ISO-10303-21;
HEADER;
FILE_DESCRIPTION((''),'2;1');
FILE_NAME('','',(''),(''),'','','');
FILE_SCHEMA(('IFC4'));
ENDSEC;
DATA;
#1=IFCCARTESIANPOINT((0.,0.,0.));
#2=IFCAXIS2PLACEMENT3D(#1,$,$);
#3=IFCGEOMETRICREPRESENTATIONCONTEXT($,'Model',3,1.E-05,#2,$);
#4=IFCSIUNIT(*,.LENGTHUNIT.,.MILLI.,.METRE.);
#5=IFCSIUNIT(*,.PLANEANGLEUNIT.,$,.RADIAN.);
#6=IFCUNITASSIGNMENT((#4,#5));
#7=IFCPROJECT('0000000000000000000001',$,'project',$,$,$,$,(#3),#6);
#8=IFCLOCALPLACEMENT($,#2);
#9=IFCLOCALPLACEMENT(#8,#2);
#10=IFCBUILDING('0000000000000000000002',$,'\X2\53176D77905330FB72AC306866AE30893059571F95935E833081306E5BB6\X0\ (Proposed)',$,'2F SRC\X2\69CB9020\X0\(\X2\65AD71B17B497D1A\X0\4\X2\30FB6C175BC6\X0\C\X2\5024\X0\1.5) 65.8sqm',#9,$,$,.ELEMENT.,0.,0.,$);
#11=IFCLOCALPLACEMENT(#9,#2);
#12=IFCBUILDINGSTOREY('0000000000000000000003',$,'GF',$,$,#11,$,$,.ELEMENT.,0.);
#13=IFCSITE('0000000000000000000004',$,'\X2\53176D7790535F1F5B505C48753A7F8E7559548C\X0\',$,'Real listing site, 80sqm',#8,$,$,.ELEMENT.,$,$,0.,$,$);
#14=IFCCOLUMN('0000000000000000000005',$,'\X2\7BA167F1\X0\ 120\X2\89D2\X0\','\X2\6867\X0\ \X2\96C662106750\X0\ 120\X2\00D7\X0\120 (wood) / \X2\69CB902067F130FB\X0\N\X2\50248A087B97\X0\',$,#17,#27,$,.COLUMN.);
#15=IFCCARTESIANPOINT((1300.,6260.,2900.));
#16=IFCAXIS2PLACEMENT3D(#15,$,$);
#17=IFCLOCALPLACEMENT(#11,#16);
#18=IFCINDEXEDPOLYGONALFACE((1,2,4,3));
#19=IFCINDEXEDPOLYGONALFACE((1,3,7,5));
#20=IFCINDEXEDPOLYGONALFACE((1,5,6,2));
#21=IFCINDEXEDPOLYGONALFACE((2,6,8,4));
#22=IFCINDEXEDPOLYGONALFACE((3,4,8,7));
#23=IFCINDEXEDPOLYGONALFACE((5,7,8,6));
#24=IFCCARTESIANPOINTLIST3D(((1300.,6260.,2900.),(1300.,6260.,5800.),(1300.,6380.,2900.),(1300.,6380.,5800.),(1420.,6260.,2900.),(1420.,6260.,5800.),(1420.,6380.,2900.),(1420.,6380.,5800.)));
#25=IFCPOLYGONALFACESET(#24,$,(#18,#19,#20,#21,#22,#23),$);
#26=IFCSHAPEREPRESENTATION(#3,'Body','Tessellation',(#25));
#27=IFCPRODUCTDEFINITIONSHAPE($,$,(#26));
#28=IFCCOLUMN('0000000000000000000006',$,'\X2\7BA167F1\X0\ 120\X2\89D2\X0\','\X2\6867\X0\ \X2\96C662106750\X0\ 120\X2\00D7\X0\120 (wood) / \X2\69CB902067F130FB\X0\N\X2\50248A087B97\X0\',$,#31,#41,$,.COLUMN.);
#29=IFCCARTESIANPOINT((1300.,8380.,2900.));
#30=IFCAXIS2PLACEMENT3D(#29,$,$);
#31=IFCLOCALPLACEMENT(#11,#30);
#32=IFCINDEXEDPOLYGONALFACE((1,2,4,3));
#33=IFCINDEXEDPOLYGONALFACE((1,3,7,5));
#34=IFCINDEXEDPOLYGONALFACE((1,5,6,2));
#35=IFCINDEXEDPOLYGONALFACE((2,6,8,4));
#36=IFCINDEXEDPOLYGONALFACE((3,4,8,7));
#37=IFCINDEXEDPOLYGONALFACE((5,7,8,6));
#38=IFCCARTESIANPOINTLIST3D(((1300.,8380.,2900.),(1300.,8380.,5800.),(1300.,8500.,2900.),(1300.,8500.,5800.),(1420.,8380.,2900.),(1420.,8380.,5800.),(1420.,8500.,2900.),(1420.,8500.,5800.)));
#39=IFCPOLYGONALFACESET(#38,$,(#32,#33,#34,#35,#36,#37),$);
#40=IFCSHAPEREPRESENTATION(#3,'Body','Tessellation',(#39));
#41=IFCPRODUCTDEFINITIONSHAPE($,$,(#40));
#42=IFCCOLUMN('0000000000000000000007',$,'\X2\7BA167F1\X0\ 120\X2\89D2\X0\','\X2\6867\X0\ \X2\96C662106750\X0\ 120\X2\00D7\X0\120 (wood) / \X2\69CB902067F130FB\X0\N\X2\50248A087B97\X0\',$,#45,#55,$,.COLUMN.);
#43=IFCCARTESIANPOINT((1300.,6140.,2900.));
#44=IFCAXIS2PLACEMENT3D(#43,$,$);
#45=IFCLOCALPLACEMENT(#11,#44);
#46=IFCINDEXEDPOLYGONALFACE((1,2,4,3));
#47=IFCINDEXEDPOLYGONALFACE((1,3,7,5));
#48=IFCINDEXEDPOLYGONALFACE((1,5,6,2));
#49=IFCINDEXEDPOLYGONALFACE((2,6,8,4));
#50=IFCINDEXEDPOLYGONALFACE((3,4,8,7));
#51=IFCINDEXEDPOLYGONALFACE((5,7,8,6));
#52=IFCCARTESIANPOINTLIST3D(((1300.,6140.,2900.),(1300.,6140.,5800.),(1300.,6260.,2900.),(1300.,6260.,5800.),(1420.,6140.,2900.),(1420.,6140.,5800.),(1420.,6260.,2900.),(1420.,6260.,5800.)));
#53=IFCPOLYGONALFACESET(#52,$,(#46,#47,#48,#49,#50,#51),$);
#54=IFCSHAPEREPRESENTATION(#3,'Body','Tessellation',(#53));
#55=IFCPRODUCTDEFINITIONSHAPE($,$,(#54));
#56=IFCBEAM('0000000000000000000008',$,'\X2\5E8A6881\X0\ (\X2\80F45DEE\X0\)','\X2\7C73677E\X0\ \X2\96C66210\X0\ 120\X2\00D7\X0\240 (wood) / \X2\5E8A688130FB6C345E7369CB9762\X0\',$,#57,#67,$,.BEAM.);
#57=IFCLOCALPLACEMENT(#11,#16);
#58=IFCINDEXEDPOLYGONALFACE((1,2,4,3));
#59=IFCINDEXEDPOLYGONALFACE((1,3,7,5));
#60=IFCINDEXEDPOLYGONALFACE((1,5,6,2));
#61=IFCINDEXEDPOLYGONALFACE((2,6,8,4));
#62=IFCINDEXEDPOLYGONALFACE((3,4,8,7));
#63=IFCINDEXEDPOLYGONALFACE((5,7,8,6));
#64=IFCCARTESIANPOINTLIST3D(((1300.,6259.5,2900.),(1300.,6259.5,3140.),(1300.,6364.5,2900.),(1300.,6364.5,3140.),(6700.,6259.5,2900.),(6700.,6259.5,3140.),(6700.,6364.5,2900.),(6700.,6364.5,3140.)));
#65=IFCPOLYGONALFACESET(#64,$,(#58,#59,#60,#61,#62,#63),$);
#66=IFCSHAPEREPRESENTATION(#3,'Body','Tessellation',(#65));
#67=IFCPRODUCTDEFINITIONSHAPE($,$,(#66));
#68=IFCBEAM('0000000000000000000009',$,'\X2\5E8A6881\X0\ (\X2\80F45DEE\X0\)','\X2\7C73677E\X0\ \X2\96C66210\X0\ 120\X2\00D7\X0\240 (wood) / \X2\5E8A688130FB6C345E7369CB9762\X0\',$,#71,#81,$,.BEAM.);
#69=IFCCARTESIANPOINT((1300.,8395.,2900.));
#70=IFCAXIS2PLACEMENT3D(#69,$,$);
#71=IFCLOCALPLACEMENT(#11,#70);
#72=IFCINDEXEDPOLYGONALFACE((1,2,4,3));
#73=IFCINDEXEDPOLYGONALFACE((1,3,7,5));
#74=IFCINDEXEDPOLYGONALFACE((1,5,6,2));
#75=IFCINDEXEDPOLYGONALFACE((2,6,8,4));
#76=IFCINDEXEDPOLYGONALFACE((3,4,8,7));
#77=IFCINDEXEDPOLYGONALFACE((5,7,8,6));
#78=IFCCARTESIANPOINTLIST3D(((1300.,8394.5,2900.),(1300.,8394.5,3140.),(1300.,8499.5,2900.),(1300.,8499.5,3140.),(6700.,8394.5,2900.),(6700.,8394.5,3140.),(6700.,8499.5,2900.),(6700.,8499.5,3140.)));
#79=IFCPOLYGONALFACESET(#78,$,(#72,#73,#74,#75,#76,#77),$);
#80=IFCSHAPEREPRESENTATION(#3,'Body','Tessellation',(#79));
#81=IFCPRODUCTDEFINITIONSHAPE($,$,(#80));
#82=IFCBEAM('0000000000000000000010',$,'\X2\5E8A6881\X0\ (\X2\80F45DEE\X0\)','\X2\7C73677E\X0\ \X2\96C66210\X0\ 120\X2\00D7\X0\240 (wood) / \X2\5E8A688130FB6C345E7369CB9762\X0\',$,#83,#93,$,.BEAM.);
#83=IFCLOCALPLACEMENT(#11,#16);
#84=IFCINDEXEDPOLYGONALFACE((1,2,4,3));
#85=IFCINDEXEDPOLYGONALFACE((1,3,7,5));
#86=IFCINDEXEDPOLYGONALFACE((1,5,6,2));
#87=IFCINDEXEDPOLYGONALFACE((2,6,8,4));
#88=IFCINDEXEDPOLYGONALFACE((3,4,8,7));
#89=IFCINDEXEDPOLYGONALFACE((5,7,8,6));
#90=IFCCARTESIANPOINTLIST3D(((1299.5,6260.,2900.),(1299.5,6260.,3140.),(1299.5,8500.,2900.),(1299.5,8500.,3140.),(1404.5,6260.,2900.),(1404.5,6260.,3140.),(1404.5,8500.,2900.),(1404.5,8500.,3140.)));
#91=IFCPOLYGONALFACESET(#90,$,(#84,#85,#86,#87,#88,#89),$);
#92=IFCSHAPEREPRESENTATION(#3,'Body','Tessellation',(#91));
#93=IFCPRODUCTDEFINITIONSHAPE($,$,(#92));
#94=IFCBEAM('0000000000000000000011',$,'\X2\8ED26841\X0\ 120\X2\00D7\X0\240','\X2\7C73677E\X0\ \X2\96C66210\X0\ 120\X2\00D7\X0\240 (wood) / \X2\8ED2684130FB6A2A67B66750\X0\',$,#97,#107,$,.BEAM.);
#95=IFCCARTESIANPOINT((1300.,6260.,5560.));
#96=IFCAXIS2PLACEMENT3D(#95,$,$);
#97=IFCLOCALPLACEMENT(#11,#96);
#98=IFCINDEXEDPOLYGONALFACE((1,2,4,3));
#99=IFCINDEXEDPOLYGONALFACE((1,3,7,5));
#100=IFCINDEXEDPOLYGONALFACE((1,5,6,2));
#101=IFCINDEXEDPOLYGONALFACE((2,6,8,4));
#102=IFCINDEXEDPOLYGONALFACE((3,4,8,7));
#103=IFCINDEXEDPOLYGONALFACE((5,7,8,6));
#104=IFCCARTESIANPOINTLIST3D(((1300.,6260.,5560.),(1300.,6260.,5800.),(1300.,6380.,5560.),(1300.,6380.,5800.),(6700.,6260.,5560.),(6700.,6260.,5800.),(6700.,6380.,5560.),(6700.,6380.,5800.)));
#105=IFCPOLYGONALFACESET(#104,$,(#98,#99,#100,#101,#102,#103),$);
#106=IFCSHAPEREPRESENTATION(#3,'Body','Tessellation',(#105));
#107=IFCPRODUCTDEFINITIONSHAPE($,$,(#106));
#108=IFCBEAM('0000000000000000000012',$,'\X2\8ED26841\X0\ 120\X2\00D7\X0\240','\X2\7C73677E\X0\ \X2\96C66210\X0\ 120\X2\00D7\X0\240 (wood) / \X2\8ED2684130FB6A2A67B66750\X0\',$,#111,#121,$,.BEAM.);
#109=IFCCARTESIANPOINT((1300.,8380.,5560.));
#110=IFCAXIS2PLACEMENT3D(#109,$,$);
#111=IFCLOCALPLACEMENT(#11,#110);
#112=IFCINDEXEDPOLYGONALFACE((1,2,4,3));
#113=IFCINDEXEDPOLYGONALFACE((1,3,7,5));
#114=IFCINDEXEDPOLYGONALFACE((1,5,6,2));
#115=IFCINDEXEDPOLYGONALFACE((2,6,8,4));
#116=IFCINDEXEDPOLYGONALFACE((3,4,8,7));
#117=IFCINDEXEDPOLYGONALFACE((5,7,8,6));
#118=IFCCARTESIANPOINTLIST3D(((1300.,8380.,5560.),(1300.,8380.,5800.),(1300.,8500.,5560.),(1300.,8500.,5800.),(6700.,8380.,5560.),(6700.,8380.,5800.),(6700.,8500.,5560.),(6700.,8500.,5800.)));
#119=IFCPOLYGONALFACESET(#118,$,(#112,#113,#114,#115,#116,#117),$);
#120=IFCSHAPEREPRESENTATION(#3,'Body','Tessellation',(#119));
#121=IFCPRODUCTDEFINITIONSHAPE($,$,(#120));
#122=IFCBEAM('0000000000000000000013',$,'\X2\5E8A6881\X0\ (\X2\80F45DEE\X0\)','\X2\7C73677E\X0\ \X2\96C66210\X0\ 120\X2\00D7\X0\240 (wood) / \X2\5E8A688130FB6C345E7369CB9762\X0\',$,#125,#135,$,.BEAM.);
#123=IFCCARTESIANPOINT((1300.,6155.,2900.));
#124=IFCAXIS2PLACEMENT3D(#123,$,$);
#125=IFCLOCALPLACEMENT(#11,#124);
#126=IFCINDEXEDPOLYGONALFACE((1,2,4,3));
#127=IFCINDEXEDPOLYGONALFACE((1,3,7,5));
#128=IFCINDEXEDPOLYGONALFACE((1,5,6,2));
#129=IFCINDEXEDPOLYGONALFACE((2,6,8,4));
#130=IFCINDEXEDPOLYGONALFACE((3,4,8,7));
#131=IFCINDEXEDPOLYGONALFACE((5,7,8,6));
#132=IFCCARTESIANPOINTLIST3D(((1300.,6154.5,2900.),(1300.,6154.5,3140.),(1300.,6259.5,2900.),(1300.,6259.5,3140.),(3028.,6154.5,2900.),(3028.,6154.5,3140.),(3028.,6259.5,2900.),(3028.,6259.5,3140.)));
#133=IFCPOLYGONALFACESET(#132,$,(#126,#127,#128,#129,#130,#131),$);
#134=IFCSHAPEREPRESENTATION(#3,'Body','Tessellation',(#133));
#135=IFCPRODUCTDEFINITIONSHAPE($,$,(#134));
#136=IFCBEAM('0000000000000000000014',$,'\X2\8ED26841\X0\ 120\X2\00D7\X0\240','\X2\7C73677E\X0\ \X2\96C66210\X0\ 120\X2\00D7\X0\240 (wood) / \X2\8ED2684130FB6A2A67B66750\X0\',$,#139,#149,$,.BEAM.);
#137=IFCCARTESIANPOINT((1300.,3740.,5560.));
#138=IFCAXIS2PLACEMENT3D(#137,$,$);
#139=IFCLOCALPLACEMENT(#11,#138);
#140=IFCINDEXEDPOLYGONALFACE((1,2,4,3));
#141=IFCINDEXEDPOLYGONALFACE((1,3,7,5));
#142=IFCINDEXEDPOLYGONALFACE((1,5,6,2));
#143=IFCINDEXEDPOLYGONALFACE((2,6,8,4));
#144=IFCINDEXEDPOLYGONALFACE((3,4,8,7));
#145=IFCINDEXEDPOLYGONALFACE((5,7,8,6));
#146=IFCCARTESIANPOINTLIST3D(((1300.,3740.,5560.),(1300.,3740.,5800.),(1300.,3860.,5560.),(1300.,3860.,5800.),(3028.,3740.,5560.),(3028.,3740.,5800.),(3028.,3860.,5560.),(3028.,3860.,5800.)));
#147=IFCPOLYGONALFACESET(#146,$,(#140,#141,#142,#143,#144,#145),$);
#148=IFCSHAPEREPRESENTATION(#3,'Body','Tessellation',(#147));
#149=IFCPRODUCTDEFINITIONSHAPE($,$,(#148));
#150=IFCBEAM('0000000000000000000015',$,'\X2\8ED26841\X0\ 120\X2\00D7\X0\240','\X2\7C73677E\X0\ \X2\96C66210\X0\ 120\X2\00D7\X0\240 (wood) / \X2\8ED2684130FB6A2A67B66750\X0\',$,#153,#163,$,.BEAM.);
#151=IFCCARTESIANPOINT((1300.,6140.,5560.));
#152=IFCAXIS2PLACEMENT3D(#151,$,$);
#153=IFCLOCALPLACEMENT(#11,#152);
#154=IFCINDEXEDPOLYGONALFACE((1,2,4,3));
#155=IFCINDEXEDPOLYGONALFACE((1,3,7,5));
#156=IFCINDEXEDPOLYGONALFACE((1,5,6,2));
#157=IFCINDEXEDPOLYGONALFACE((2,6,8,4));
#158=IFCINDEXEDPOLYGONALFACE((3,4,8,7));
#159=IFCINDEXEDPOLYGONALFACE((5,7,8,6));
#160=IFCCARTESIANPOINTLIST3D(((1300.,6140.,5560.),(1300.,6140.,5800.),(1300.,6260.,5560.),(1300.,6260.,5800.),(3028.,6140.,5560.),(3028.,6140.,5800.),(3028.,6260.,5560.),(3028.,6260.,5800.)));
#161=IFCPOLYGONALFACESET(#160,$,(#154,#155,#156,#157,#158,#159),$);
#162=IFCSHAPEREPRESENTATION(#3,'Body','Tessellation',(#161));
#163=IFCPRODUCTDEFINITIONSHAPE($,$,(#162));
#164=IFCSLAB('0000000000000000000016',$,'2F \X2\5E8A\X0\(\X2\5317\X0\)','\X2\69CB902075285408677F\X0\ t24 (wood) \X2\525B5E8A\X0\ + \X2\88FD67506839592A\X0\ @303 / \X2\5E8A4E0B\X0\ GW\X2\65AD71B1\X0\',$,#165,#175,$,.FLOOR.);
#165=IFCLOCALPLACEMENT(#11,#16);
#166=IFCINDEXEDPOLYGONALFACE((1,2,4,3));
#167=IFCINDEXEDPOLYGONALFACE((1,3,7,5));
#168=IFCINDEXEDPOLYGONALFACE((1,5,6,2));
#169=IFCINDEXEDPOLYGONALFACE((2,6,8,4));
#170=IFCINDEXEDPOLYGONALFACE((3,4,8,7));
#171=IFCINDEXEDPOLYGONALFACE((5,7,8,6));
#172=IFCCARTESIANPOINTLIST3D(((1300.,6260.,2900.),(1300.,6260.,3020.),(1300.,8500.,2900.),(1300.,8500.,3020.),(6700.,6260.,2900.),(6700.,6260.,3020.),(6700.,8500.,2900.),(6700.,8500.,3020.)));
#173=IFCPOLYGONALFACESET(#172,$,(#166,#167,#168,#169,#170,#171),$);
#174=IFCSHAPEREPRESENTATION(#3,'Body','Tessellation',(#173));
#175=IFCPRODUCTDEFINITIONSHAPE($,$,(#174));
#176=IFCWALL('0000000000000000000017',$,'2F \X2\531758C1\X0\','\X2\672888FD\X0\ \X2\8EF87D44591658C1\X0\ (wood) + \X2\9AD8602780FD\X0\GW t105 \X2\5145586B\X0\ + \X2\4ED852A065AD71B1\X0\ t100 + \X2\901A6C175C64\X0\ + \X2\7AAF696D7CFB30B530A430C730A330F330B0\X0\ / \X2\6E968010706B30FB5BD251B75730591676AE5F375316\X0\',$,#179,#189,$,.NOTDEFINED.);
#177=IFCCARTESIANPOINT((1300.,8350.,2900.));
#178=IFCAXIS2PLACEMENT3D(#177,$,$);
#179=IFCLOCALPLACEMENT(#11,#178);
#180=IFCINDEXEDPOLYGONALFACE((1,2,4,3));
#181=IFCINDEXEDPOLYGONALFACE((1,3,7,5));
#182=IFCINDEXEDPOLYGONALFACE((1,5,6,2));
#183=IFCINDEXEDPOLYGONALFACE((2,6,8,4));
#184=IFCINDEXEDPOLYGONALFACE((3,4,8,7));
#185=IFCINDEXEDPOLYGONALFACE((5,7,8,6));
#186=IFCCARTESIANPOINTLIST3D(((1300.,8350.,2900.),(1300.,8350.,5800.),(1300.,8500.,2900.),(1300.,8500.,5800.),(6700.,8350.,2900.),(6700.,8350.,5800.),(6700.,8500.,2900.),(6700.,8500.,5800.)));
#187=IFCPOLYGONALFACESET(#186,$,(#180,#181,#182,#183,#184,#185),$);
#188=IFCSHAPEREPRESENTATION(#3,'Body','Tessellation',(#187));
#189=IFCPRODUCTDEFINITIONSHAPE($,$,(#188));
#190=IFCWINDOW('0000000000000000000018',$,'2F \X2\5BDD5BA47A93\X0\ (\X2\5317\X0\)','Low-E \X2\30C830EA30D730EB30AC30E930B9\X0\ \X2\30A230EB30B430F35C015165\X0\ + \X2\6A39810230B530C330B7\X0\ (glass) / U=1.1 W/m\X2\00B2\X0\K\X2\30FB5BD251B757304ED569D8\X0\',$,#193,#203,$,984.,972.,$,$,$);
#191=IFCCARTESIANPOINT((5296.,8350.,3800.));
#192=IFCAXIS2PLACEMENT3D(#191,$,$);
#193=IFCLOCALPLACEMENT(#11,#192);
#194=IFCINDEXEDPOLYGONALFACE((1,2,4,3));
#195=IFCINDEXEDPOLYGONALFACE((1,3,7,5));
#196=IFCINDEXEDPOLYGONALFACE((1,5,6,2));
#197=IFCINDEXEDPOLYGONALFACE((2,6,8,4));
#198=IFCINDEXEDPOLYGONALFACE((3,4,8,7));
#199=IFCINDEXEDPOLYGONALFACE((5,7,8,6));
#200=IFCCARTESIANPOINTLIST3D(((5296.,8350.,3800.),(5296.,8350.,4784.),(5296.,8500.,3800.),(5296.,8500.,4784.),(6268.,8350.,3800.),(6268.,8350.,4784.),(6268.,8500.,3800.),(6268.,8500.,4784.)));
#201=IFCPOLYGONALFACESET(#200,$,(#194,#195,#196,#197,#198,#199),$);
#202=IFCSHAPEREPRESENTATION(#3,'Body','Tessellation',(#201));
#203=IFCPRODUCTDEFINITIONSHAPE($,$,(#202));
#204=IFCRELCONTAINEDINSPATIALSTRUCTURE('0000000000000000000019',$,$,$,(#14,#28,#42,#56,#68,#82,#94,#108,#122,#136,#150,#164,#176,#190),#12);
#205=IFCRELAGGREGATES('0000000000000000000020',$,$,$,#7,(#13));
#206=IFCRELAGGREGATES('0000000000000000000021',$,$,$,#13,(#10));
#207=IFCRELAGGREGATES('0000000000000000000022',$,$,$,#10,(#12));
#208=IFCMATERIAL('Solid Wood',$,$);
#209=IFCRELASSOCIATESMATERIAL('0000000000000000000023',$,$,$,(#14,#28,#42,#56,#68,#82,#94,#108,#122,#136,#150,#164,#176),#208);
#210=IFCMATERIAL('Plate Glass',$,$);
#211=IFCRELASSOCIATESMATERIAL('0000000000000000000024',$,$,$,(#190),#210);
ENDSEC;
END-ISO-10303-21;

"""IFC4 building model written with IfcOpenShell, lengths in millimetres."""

from ifc_helpers import new_model, si_unit, frame, frame_2d, origin, place, context, project, spatial, rectangle, extrude, material, element, fill, save


model = new_model("IFC4")

# Units and contexts
model_context = context("Model", 3, precision=1e-05, world=origin())
ifc_project = project(units=[si_unit("LENGTHUNIT", "METRE", prefix="MILLI"), si_unit("PLANEANGLEUNIT", "RADIAN")], contexts=[model_context])

# Site, building, storey
site_placement = place(None, origin())
site = spatial("IfcSite", under=ifc_project, at=site_placement, Name="北海道弟子屈町美留和", ObjectType="Real listing site, 80sqm", CompositionType="ELEMENT", RefElevation=0.0)
building_placement = place(site_placement, origin())
building = spatial("IfcBuilding", under=site, at=building_placement, Name="北海道・犬と暮らす土間広めの家 (Proposed)", ObjectType="2F SRC構造(断熱等級4・気密C値1.5) 65.8sqm", CompositionType="ELEMENT", ElevationOfRefHeight=0.0, ElevationOfTerrain=0.0)
storey_placement = place(building_placement, origin())
storey = spatial("IfcBuildingStorey", under=building, at=storey_placement, Name="GF", CompositionType="ELEMENT", Elevation=0.0)

# Columns
ifc_material_1 = material(Name="Solid Wood")
column_1_placement = place(storey_placement, frame((1300.0, 6260.0, 2900.0)))
element("IfcColumn", 1, at=column_1_placement, inside=storey, material=ifc_material_1, Name="管柱 120角", Description="桧 集成材 120×120 (wood) / 構造柱・N値計算", PredefinedType="COLUMN", context=model_context, shape_type="SweptSolid", body=[
    extrude(rectangle(XDim=120.0, YDim=120.0, at=frame_2d((60.0, 60.0))), frame((1300.0, 6260.0, 2900.0)), (0.0, 0.0, 1.0), 2900.0),
])
column_2_placement = place(storey_placement, frame((1300.0, 8380.0, 2900.0)))
element("IfcColumn", 2, at=column_2_placement, inside=storey, material=ifc_material_1, Name="管柱 120角", Description="桧 集成材 120×120 (wood) / 構造柱・N値計算", PredefinedType="COLUMN", context=model_context, shape_type="SweptSolid", body=[
    extrude(rectangle(XDim=120.0, YDim=120.0, at=frame_2d((60.0, 60.0))), frame((1300.0, 8380.0, 2900.0)), (0.0, 0.0, 1.0), 2900.0),
])
column_3_placement = place(storey_placement, frame((1300.0, 6140.0, 2900.0)))
element("IfcColumn", 3, at=column_3_placement, inside=storey, material=ifc_material_1, Name="管柱 120角", Description="桧 集成材 120×120 (wood) / 構造柱・N値計算", PredefinedType="COLUMN", context=model_context, shape_type="SweptSolid", body=[
    extrude(rectangle(XDim=120.0, YDim=120.0, at=frame_2d((60.0, 60.0))), frame((1300.0, 6140.0, 2900.0)), (0.0, 0.0, 1.0), 2900.0),
])

# Beams
beam_1_placement = place(storey_placement, frame((1300.0, 6260.0, 2900.0)))
element("IfcBeam", 4, at=beam_1_placement, inside=storey, material=ifc_material_1, Name="床梁 (胴差)", Description="米松 集成 120×240 (wood) / 床梁・水平構面", PredefinedType="BEAM", context=model_context, shape_type="SweptSolid", body=[
    extrude(rectangle(XDim=5400.0, YDim=105.0, at=frame_2d((2700.0, 52.0))), frame((1300.0, 6260.0, 2900.0)), (0.0, 0.0, 1.0), 240.0),
])
beam_2_placement = place(storey_placement, frame((1300.0, 8395.0, 2900.0)))
element("IfcBeam", 5, at=beam_2_placement, inside=storey, material=ifc_material_1, Name="床梁 (胴差)", Description="米松 集成 120×240 (wood) / 床梁・水平構面", PredefinedType="BEAM", context=model_context, shape_type="SweptSolid", body=[
    extrude(rectangle(XDim=5400.0, YDim=105.0, at=frame_2d((2700.0, 52.0))), frame((1300.0, 8395.0, 2900.0)), (0.0, 0.0, 1.0), 240.0),
])
beam_3_placement = place(storey_placement, frame((1300.0, 6260.0, 2900.0)))
element("IfcBeam", 6, at=beam_3_placement, inside=storey, material=ifc_material_1, Name="床梁 (胴差)", Description="米松 集成 120×240 (wood) / 床梁・水平構面", PredefinedType="BEAM", context=model_context, shape_type="SweptSolid", body=[
    extrude(rectangle(XDim=105.0, YDim=2240.0, at=frame_2d((52.0, 1120.0))), frame((1300.0, 6260.0, 2900.0)), (0.0, 0.0, 1.0), 240.0),
])
beam_4_placement = place(storey_placement, frame((1300.0, 6260.0, 5560.0)))
element("IfcBeam", 7, at=beam_4_placement, inside=storey, material=ifc_material_1, Name="軒桁 120×240", Description="米松 集成 120×240 (wood) / 軒桁・横架材", PredefinedType="BEAM", context=model_context, shape_type="SweptSolid", body=[
    extrude(rectangle(XDim=5400.0, YDim=120.0, at=frame_2d((2700.0, 60.0))), frame((1300.0, 6260.0, 5560.0)), (0.0, 0.0, 1.0), 240.0),
])
beam_5_placement = place(storey_placement, frame((1300.0, 8380.0, 5560.0)))
element("IfcBeam", 8, at=beam_5_placement, inside=storey, material=ifc_material_1, Name="軒桁 120×240", Description="米松 集成 120×240 (wood) / 軒桁・横架材", PredefinedType="BEAM", context=model_context, shape_type="SweptSolid", body=[
    extrude(rectangle(XDim=5400.0, YDim=120.0, at=frame_2d((2700.0, 60.0))), frame((1300.0, 8380.0, 5560.0)), (0.0, 0.0, 1.0), 240.0),
])
beam_6_placement = place(storey_placement, frame((1300.0, 6155.0, 2900.0)))
element("IfcBeam", 9, at=beam_6_placement, inside=storey, material=ifc_material_1, Name="床梁 (胴差)", Description="米松 集成 120×240 (wood) / 床梁・水平構面", PredefinedType="BEAM", context=model_context, shape_type="SweptSolid", body=[
    extrude(rectangle(XDim=1728.0, YDim=105.0, at=frame_2d((864.0, 52.0))), frame((1300.0, 6155.0, 2900.0)), (0.0, 0.0, 1.0), 240.0),
])
beam_7_placement = place(storey_placement, frame((1300.0, 3740.0, 5560.0)))
element("IfcBeam", 10, at=beam_7_placement, inside=storey, material=ifc_material_1, Name="軒桁 120×240", Description="米松 集成 120×240 (wood) / 軒桁・横架材", PredefinedType="BEAM", context=model_context, shape_type="SweptSolid", body=[
    extrude(rectangle(XDim=1728.0, YDim=120.0, at=frame_2d((864.0, 60.0))), frame((1300.0, 3740.0, 5560.0)), (0.0, 0.0, 1.0), 240.0),
])
beam_8_placement = place(storey_placement, frame((1300.0, 6140.0, 5560.0)))
element("IfcBeam", 11, at=beam_8_placement, inside=storey, material=ifc_material_1, Name="軒桁 120×240", Description="米松 集成 120×240 (wood) / 軒桁・横架材", PredefinedType="BEAM", context=model_context, shape_type="SweptSolid", body=[
    extrude(rectangle(XDim=1728.0, YDim=120.0, at=frame_2d((864.0, 60.0))), frame((1300.0, 6140.0, 5560.0)), (0.0, 0.0, 1.0), 240.0),
])

# Slab
slab_placement = place(storey_placement, frame((1300.0, 6260.0, 2900.0)))
element("IfcSlab", 12, at=slab_placement, inside=storey, material=ifc_material_1, Name="2F 床(北)", Description="構造用合板 t24 (wood) 剛床 + 製材根太 @303 / 床下 GW断熱", PredefinedType="FLOOR", context=model_context, shape_type="SweptSolid", body=[
    extrude(rectangle(XDim=5400.0, YDim=2240.0, at=frame_2d((2700.0, 1120.0))), frame((1300.0, 6260.0, 2900.0)), (0.0, 0.0, 1.0), 120.0),
])

# Wall, opening, window
wall_placement = place(storey_placement, frame((1300.0, 8350.0, 2900.0)))
wall = element("IfcWall", 13, at=wall_placement, inside=storey, material=ifc_material_1, Name="2F 北壁", Description="木製 軸組外壁 (wood) + 高性能GW t105 充填 + 付加断熱 t100 + 通気層 + 窯業系サイディング / 準耐火・寒冷地外皮強化", PredefinedType="NOTDEFINED", context=model_context, shape_type="SweptSolid", body=[
    extrude(rectangle(XDim=5400.0, YDim=150.0, at=frame_2d((2700.0, 75.0))), frame((1300.0, 8350.0, 2900.0)), (0.0, 0.0, 1.0), 2900.0),
])
opening_placement = place(storey_placement, frame((5296.0, 8350.0, 3800.0)))
opening = element("IfcOpeningElement", 14, at=opening_placement, cuts=wall, PredefinedType="NOTDEFINED", context=model_context, shape_type="SweptSolid", body=[
    extrude(rectangle(XDim=972.0, YDim=150.0, at=frame_2d((486.0, 75.0))), frame((5296.0, 8350.0, 3800.0)), (0.0, 0.0, 1.0), 984.0),
])
ifc_material_2 = material(Name="Plate Glass")
window_placement = place(storey_placement, frame((5296.0, 8350.0, 3800.0)))
window = element("IfcWindow", 15, at=window_placement, inside=storey, material=ifc_material_2, Name="2F 寝室窓 (北)", Description="Low-E トリプルガラス アルゴン封入 + 樹脂サッシ (glass) / U=1.1 W/m²K・寒冷地仕様", OverallHeight=984.0, OverallWidth=972.0, context=model_context, shape_type="SweptSolid", body=[
    extrude(rectangle(XDim=972.0, YDim=150.0, at=frame_2d((486.0, 75.0))), frame((5296.0, 8350.0, 3800.0)), (0.0, 0.0, 1.0), 984.0),
])
fill(opening, window)

save(model, "model.ifc")
